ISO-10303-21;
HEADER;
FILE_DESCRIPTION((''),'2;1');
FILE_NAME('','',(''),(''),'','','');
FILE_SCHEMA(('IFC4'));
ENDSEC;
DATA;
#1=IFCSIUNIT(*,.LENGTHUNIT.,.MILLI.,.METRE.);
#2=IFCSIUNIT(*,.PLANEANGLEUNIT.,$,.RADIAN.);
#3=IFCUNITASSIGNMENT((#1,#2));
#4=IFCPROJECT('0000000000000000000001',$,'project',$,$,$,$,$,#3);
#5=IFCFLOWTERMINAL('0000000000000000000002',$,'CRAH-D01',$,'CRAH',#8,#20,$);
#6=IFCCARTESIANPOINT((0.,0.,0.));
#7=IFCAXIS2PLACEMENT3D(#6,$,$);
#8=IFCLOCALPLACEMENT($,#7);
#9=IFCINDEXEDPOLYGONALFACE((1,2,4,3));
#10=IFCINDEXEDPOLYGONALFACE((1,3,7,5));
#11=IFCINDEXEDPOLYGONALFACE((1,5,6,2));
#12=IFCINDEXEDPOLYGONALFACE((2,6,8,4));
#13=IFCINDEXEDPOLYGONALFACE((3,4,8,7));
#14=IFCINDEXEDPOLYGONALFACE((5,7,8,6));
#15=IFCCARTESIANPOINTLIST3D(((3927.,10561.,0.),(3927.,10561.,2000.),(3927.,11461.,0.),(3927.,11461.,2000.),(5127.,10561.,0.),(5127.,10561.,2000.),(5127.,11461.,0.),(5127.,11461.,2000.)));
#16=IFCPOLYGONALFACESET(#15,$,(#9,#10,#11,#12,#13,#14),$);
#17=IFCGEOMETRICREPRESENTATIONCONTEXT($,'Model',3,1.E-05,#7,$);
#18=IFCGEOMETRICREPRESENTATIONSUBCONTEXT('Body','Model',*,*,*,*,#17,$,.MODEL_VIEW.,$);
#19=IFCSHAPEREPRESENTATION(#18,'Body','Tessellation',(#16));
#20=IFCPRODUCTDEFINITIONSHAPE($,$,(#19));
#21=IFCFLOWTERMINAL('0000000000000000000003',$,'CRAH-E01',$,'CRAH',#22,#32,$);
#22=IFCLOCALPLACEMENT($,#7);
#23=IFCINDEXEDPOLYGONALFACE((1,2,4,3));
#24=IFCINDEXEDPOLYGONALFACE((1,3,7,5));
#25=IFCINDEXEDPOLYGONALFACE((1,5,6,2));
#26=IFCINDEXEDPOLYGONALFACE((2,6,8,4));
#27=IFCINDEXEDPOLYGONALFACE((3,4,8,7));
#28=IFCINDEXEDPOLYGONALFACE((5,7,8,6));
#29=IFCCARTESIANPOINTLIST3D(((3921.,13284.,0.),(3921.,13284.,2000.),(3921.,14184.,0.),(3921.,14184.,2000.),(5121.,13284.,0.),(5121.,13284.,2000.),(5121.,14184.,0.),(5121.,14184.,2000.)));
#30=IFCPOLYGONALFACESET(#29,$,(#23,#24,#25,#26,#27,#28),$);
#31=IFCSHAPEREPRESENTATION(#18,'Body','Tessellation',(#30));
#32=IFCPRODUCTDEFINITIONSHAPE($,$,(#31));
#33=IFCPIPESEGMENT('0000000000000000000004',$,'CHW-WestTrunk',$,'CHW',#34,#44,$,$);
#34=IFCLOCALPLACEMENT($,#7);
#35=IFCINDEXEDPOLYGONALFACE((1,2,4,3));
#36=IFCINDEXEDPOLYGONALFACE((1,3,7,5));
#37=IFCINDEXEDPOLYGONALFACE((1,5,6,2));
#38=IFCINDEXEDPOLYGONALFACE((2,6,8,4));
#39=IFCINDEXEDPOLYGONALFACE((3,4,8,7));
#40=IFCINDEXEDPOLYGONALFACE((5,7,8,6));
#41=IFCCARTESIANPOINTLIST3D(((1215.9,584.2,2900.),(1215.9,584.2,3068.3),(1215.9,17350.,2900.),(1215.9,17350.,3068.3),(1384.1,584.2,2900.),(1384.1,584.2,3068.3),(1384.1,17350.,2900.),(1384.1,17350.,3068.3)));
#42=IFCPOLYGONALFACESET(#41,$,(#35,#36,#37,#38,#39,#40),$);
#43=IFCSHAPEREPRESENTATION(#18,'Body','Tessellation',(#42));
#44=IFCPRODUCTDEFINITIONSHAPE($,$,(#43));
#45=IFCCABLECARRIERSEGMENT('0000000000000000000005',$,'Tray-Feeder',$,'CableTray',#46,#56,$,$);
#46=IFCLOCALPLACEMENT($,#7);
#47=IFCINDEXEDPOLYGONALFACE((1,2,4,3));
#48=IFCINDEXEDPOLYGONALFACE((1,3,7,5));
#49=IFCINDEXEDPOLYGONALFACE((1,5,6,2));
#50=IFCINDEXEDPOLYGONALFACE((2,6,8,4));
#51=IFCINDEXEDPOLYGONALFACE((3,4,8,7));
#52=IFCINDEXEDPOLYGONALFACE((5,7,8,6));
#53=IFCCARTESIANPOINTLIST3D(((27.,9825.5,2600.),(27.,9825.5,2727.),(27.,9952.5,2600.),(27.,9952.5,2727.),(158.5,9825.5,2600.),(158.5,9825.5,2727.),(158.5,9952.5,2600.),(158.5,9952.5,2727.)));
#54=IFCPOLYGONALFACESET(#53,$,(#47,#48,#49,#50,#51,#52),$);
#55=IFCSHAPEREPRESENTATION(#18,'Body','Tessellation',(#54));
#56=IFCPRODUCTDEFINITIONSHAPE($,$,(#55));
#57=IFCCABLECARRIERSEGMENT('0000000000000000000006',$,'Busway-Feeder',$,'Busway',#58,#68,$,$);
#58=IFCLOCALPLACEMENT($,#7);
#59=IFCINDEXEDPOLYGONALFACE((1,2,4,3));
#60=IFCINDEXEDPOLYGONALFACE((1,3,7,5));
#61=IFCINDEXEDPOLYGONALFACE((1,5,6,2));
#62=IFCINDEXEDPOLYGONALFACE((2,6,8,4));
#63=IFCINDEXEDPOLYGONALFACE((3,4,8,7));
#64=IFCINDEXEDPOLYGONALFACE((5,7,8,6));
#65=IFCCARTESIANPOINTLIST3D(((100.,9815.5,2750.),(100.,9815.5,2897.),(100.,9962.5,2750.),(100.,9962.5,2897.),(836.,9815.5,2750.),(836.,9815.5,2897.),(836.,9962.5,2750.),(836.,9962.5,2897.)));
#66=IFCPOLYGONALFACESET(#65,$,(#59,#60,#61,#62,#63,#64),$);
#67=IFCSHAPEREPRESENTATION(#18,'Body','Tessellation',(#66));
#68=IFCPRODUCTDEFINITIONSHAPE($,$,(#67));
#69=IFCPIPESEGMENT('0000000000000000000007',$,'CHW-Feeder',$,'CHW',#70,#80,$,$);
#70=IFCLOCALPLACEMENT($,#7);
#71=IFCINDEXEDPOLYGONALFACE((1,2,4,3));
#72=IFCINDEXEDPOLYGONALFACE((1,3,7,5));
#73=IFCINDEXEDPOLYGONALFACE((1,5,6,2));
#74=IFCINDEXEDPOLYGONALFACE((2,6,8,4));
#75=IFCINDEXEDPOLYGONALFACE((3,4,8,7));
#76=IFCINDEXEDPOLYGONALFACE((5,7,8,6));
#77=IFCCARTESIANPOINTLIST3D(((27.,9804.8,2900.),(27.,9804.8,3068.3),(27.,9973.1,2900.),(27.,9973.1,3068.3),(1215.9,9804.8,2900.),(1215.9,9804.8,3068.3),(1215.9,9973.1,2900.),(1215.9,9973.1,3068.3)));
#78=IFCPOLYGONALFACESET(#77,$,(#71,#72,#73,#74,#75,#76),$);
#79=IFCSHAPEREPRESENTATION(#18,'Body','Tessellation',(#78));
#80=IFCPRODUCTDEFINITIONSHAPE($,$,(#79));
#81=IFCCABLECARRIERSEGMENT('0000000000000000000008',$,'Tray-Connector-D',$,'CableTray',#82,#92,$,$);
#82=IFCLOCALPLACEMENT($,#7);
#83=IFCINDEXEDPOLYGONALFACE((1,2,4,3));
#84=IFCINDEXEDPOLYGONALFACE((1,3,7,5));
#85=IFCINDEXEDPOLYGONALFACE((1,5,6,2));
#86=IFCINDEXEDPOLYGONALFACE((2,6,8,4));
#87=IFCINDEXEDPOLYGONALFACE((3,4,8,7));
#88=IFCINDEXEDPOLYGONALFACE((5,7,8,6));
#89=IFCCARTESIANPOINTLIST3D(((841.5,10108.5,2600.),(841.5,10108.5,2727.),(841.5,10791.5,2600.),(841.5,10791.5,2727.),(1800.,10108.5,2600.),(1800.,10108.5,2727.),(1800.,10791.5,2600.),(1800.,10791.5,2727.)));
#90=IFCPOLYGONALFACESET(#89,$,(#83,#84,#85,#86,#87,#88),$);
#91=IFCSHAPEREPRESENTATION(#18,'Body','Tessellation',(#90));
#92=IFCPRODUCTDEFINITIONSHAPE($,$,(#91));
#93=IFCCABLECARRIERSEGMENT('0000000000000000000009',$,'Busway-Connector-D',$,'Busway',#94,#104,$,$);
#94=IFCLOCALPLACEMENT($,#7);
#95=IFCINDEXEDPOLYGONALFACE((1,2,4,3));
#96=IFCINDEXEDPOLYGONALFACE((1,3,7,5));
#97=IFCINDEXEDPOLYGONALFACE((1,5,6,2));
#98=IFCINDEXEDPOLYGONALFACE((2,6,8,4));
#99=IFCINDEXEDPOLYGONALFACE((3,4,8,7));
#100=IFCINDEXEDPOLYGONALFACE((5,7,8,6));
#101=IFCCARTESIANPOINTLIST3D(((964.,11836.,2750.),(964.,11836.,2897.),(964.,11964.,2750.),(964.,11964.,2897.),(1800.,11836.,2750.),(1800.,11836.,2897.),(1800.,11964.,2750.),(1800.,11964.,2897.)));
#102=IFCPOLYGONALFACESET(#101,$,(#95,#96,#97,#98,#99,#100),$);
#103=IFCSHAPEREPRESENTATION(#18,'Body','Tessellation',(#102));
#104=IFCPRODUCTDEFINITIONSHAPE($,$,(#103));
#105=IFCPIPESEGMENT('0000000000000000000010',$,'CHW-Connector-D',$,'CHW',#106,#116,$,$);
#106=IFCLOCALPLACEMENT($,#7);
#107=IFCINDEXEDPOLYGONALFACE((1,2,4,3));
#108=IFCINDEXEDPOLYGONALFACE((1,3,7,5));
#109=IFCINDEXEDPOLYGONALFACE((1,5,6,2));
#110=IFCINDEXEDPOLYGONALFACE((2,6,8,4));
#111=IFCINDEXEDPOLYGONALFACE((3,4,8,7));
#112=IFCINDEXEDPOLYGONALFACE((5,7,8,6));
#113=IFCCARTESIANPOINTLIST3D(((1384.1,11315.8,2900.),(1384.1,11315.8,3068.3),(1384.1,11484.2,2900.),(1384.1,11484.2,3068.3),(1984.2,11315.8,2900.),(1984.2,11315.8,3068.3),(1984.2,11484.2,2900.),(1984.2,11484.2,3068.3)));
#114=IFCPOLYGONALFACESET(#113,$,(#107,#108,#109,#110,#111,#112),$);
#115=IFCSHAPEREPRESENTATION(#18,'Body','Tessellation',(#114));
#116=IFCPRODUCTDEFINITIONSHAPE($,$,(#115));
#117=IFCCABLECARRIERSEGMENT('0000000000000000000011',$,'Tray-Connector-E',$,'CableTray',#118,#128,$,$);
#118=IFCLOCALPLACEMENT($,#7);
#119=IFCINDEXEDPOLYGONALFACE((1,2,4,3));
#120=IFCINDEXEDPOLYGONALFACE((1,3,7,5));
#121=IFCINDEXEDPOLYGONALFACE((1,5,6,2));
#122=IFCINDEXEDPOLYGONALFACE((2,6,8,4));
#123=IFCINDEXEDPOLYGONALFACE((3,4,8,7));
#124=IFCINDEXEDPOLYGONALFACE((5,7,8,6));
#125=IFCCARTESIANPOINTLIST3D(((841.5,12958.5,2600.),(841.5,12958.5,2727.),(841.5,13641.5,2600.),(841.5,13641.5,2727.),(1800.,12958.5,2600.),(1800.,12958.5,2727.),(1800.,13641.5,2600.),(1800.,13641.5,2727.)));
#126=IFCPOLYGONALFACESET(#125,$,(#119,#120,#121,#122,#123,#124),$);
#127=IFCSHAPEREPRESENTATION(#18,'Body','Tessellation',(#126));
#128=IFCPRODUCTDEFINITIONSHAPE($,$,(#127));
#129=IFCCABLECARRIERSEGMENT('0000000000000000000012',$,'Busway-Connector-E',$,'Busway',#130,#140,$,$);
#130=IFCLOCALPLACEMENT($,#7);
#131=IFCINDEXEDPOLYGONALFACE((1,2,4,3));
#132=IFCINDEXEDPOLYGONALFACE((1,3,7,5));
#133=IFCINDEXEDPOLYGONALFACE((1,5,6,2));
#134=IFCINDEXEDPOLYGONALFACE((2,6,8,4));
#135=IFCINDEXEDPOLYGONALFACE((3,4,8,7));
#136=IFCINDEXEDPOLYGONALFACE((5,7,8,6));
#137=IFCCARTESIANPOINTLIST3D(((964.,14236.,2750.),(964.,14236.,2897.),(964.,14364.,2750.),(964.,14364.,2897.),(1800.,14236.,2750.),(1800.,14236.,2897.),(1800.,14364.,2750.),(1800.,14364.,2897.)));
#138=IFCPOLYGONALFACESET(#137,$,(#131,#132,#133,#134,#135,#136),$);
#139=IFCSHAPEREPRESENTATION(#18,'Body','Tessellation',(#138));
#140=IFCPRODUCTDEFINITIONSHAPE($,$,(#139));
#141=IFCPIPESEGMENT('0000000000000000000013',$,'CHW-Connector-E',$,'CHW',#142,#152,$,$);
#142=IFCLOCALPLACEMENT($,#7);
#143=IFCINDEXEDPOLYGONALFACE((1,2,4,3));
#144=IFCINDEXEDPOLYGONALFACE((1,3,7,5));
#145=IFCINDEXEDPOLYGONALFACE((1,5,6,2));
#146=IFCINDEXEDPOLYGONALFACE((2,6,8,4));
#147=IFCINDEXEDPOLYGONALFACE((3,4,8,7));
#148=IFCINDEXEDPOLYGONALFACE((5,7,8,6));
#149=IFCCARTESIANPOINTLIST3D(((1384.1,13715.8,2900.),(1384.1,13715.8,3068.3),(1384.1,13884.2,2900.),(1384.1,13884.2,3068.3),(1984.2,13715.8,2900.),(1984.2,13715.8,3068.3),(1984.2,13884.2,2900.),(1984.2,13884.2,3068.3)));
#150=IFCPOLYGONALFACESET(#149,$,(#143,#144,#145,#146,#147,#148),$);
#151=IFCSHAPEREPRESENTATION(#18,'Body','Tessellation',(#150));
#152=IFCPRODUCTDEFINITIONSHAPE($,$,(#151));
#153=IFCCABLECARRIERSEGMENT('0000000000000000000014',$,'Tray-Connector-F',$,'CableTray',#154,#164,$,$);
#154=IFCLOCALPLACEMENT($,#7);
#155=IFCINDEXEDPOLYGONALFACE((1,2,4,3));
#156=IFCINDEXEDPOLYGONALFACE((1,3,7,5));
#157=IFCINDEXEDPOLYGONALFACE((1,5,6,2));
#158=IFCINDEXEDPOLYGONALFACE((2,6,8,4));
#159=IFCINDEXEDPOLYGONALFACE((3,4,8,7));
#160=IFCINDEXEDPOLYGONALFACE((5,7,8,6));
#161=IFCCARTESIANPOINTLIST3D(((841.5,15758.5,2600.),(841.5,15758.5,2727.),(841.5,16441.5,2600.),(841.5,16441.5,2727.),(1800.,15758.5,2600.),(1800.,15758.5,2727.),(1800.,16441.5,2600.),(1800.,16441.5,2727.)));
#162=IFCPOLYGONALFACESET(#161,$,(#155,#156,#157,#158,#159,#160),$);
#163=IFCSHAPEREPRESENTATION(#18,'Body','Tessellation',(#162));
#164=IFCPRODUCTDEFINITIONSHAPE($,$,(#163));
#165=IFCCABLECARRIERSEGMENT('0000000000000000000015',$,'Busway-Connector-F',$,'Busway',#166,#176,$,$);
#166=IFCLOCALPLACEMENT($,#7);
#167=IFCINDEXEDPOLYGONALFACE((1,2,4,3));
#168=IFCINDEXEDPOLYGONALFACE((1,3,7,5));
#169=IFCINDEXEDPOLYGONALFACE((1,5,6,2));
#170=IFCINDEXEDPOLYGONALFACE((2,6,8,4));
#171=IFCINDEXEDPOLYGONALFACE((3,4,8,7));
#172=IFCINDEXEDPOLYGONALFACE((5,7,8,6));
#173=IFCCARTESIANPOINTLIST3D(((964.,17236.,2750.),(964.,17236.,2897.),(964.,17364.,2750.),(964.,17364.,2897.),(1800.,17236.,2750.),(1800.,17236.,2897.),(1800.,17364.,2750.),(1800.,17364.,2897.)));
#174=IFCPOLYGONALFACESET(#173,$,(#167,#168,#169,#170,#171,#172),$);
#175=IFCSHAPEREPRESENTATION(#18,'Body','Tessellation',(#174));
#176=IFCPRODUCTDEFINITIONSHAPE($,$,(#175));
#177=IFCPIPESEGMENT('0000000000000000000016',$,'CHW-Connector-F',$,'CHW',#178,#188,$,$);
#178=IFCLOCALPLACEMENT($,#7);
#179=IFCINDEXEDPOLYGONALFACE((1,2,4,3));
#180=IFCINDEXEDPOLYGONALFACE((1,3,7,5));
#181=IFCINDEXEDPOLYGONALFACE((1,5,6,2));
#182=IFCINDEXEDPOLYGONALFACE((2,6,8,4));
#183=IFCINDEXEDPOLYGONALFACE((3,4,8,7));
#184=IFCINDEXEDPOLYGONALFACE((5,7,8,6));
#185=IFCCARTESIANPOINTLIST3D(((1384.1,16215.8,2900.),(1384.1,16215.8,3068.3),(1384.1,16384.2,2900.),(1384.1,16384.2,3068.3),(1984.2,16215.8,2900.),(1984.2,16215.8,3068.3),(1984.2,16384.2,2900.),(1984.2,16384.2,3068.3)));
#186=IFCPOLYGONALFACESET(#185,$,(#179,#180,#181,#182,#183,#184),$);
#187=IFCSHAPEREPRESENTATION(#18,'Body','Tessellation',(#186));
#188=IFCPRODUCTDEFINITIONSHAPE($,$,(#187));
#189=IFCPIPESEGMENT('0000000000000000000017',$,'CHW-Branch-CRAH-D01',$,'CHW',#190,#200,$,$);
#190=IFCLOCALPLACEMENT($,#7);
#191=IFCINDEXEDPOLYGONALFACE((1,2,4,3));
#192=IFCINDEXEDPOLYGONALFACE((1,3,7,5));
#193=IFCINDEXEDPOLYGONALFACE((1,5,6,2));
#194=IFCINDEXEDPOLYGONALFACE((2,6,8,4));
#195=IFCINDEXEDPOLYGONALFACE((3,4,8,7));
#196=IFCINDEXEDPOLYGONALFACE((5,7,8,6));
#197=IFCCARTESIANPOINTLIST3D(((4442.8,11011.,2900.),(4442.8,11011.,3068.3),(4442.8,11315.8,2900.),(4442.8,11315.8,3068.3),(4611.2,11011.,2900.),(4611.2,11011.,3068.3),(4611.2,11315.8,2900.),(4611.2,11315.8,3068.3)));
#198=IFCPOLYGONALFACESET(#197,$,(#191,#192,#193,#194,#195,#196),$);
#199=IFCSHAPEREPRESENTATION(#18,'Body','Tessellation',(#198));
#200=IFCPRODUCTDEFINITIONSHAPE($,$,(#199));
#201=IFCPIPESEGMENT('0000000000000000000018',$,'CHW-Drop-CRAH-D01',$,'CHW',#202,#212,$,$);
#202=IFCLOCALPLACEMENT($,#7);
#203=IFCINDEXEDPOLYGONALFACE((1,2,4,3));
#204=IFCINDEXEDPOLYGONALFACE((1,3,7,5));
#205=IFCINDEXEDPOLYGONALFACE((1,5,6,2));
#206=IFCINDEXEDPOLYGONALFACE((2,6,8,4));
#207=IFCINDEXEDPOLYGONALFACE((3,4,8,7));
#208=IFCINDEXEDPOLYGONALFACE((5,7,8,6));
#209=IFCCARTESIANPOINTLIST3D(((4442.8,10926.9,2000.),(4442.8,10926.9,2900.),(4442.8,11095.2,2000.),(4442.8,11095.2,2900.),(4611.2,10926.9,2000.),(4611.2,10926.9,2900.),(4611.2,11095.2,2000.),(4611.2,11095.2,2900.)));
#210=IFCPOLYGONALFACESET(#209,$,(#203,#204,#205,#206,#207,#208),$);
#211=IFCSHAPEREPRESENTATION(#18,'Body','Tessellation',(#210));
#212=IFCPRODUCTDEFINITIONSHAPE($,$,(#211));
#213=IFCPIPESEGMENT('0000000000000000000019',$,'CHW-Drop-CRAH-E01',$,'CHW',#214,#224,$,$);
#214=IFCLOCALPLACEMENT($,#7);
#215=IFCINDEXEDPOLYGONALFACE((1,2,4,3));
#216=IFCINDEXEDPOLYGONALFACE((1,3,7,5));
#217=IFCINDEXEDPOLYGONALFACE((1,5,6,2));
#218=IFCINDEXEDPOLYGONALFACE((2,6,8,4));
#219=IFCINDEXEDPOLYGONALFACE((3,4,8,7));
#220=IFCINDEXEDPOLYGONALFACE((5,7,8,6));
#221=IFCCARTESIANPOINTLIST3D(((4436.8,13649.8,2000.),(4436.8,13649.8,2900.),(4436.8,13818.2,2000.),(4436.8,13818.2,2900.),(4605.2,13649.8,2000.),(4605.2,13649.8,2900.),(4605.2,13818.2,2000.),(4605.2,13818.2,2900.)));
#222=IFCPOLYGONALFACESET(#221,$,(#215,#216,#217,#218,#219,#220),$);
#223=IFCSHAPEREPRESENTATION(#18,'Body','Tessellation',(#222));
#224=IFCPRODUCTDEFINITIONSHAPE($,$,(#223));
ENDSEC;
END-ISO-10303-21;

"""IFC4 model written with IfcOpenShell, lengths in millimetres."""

from ifc_helpers import new_model, si_unit, frame, origin, place, context, subcontext, project, rectangle, extrude, element, save


model = new_model("IFC4")

# Units and contexts
model_context = context("Model", 3, precision=1e-05, world=origin())
body_context = subcontext(model_context, "Body", "Model", "MODEL_VIEW")
ifc_project = project(units=[si_unit("LENGTHUNIT", "METRE", prefix="MILLI"), si_unit("PLANEANGLEUNIT", "RADIAN")])

# Flow terminals
for number, where, name in (
    (1, (4527.0, 11011.0, 0.0), "CRAH-D01"),
    (2, (4521.0, 13734.0, 0.0), "CRAH-E01"),
):
    element("IfcFlowTerminal", number, at=place(None, frame(where)), Name=name, ObjectType="CRAH", context=body_context, shape_type="SweptSolid", body=[
        extrude(rectangle(XDim=1200.0, YDim=900.0), None, (0.0, 0.0, 1.0), 2000.0),
    ])

# Pipe segment
pipe_segment_1_placement = place(None, frame((1300.0, 8967.1, 2900.0)))
element("IfcPipeSegment", 3, at=pipe_segment_1_placement, Name="CHW-WestTrunk", ObjectType="CHW", context=body_context, shape_type="SweptSolid", body=[
    extrude(rectangle(XDim=168.3, YDim=16765.8), None, (0.0, 0.0, 1.0), 168.3),
])

# Cable carrier segments
cable_carrier_segment_1_placement = place(None, frame((92.8, 9889.0, 2600.0)))
element("IfcCableCarrierSegment", 4, at=cable_carrier_segment_1_placement, Name="Tray-Feeder", ObjectType="CableTray", context=body_context, shape_type="SweptSolid", body=[
    extrude(rectangle(XDim=131.5, YDim=127.0), None, (0.0, 0.0, 1.0), 127.0),
])
cable_carrier_segment_2_placement = place(None, frame((468.0, 9889.0, 2750.0)))
element("IfcCableCarrierSegment", 5, at=cable_carrier_segment_2_placement, Name="Busway-Feeder", ObjectType="Busway", context=body_context, shape_type="SweptSolid", body=[
    extrude(rectangle(XDim=736.0, YDim=147.0), None, (0.0, 0.0, 1.0), 147.0),
])

# Pipe segment
pipe_segment_2_placement = place(None, frame((621.4, 9889.0, 2900.0)))
element("IfcPipeSegment", 6, at=pipe_segment_2_placement, Name="CHW-Feeder", ObjectType="CHW", context=body_context, shape_type="SweptSolid", body=[
    extrude(rectangle(XDim=1188.8, YDim=168.3), None, (0.0, 0.0, 1.0), 168.3),
])

# Cable carrier segments
cable_carrier_segment_3_placement = place(None, frame((1320.8, 10450.0, 2600.0)))
element("IfcCableCarrierSegment", 7, at=cable_carrier_segment_3_placement, Name="Tray-Connector-D", ObjectType="CableTray", context=body_context, shape_type="SweptSolid", body=[
    extrude(rectangle(XDim=958.5, YDim=683.0), None, (0.0, 0.0, 1.0), 127.0),
])
cable_carrier_segment_4_placement = place(None, frame((1382.0, 11900.0, 2750.0)))
element("IfcCableCarrierSegment", 8, at=cable_carrier_segment_4_placement, Name="Busway-Connector-D", ObjectType="Busway", context=body_context, shape_type="SweptSolid", body=[
    extrude(rectangle(XDim=836.0, YDim=128.0), None, (0.0, 0.0, 1.0), 147.0),
])

# Pipe segment
pipe_segment_3_placement = place(None, frame((1684.2, 11400.0, 2900.0)))
element("IfcPipeSegment", 9, at=pipe_segment_3_placement, Name="CHW-Connector-D", ObjectType="CHW", context=body_context, shape_type="SweptSolid", body=[
    extrude(rectangle(XDim=600.0, YDim=168.3), None, (0.0, 0.0, 1.0), 168.3),
])

# Cable carrier segments
cable_carrier_segment_5_placement = place(None, frame((1320.8, 13300.0, 2600.0)))
element("IfcCableCarrierSegment", 10, at=cable_carrier_segment_5_placement, Name="Tray-Connector-E", ObjectType="CableTray", context=body_context, shape_type="SweptSolid", body=[
    extrude(rectangle(XDim=958.5, YDim=683.0), None, (0.0, 0.0, 1.0), 127.0),
])
cable_carrier_segment_6_placement = place(None, frame((1382.0, 14300.0, 2750.0)))
element("IfcCableCarrierSegment", 11, at=cable_carrier_segment_6_placement, Name="Busway-Connector-E", ObjectType="Busway", context=body_context, shape_type="SweptSolid", body=[
    extrude(rectangle(XDim=836.0, YDim=128.0), None, (0.0, 0.0, 1.0), 147.0),
])

# Pipe segment
pipe_segment_4_placement = place(None, frame((1684.2, 13800.0, 2900.0)))
element("IfcPipeSegment", 12, at=pipe_segment_4_placement, Name="CHW-Connector-E", ObjectType="CHW", context=body_context, shape_type="SweptSolid", body=[
    extrude(rectangle(XDim=600.0, YDim=168.3), None, (0.0, 0.0, 1.0), 168.3),
])

# Cable carrier segments
cable_carrier_segment_7_placement = place(None, frame((1320.8, 16100.0, 2600.0)))
element("IfcCableCarrierSegment", 13, at=cable_carrier_segment_7_placement, Name="Tray-Connector-F", ObjectType="CableTray", context=body_context, shape_type="SweptSolid", body=[
    extrude(rectangle(XDim=958.5, YDim=683.0), None, (0.0, 0.0, 1.0), 127.0),
])
cable_carrier_segment_8_placement = place(None, frame((1382.0, 17300.0, 2750.0)))
element("IfcCableCarrierSegment", 14, at=cable_carrier_segment_8_placement, Name="Busway-Connector-F", ObjectType="Busway", context=body_context, shape_type="SweptSolid", body=[
    extrude(rectangle(XDim=836.0, YDim=128.0), None, (0.0, 0.0, 1.0), 147.0),
])

# Pipe segments
pipe_segment_5_placement = place(None, frame((1684.2, 16300.0, 2900.0)))
element("IfcPipeSegment", 15, at=pipe_segment_5_placement, Name="CHW-Connector-F", ObjectType="CHW", context=body_context, shape_type="SweptSolid", body=[
    extrude(rectangle(XDim=600.0, YDim=168.3), None, (0.0, 0.0, 1.0), 168.3),
])
pipe_segment_6_placement = place(None, frame((4527.0, 11163.4, 2900.0)))
element("IfcPipeSegment", 16, at=pipe_segment_6_placement, Name="CHW-Branch-CRAH-D01", ObjectType="CHW", context=body_context, shape_type="SweptSolid", body=[
    extrude(rectangle(XDim=168.3, YDim=304.9), None, (0.0, 0.0, 1.0), 168.3),
])
for number, where, name in (
    (17, (4527.0, 11011.0, 2000.0), "CHW-Drop-CRAH-D01"),
    (18, (4521.0, 13734.0, 2000.0), "CHW-Drop-CRAH-E01"),
):
    element("IfcPipeSegment", number, at=place(None, frame(where)), Name=name, ObjectType="CHW", context=body_context, shape_type="SweptSolid", body=[
        extrude(rectangle(XDim=168.3, YDim=168.3), None, (0.0, 0.0, 1.0), 900.0),
    ])

save(model, "model.ifc")
